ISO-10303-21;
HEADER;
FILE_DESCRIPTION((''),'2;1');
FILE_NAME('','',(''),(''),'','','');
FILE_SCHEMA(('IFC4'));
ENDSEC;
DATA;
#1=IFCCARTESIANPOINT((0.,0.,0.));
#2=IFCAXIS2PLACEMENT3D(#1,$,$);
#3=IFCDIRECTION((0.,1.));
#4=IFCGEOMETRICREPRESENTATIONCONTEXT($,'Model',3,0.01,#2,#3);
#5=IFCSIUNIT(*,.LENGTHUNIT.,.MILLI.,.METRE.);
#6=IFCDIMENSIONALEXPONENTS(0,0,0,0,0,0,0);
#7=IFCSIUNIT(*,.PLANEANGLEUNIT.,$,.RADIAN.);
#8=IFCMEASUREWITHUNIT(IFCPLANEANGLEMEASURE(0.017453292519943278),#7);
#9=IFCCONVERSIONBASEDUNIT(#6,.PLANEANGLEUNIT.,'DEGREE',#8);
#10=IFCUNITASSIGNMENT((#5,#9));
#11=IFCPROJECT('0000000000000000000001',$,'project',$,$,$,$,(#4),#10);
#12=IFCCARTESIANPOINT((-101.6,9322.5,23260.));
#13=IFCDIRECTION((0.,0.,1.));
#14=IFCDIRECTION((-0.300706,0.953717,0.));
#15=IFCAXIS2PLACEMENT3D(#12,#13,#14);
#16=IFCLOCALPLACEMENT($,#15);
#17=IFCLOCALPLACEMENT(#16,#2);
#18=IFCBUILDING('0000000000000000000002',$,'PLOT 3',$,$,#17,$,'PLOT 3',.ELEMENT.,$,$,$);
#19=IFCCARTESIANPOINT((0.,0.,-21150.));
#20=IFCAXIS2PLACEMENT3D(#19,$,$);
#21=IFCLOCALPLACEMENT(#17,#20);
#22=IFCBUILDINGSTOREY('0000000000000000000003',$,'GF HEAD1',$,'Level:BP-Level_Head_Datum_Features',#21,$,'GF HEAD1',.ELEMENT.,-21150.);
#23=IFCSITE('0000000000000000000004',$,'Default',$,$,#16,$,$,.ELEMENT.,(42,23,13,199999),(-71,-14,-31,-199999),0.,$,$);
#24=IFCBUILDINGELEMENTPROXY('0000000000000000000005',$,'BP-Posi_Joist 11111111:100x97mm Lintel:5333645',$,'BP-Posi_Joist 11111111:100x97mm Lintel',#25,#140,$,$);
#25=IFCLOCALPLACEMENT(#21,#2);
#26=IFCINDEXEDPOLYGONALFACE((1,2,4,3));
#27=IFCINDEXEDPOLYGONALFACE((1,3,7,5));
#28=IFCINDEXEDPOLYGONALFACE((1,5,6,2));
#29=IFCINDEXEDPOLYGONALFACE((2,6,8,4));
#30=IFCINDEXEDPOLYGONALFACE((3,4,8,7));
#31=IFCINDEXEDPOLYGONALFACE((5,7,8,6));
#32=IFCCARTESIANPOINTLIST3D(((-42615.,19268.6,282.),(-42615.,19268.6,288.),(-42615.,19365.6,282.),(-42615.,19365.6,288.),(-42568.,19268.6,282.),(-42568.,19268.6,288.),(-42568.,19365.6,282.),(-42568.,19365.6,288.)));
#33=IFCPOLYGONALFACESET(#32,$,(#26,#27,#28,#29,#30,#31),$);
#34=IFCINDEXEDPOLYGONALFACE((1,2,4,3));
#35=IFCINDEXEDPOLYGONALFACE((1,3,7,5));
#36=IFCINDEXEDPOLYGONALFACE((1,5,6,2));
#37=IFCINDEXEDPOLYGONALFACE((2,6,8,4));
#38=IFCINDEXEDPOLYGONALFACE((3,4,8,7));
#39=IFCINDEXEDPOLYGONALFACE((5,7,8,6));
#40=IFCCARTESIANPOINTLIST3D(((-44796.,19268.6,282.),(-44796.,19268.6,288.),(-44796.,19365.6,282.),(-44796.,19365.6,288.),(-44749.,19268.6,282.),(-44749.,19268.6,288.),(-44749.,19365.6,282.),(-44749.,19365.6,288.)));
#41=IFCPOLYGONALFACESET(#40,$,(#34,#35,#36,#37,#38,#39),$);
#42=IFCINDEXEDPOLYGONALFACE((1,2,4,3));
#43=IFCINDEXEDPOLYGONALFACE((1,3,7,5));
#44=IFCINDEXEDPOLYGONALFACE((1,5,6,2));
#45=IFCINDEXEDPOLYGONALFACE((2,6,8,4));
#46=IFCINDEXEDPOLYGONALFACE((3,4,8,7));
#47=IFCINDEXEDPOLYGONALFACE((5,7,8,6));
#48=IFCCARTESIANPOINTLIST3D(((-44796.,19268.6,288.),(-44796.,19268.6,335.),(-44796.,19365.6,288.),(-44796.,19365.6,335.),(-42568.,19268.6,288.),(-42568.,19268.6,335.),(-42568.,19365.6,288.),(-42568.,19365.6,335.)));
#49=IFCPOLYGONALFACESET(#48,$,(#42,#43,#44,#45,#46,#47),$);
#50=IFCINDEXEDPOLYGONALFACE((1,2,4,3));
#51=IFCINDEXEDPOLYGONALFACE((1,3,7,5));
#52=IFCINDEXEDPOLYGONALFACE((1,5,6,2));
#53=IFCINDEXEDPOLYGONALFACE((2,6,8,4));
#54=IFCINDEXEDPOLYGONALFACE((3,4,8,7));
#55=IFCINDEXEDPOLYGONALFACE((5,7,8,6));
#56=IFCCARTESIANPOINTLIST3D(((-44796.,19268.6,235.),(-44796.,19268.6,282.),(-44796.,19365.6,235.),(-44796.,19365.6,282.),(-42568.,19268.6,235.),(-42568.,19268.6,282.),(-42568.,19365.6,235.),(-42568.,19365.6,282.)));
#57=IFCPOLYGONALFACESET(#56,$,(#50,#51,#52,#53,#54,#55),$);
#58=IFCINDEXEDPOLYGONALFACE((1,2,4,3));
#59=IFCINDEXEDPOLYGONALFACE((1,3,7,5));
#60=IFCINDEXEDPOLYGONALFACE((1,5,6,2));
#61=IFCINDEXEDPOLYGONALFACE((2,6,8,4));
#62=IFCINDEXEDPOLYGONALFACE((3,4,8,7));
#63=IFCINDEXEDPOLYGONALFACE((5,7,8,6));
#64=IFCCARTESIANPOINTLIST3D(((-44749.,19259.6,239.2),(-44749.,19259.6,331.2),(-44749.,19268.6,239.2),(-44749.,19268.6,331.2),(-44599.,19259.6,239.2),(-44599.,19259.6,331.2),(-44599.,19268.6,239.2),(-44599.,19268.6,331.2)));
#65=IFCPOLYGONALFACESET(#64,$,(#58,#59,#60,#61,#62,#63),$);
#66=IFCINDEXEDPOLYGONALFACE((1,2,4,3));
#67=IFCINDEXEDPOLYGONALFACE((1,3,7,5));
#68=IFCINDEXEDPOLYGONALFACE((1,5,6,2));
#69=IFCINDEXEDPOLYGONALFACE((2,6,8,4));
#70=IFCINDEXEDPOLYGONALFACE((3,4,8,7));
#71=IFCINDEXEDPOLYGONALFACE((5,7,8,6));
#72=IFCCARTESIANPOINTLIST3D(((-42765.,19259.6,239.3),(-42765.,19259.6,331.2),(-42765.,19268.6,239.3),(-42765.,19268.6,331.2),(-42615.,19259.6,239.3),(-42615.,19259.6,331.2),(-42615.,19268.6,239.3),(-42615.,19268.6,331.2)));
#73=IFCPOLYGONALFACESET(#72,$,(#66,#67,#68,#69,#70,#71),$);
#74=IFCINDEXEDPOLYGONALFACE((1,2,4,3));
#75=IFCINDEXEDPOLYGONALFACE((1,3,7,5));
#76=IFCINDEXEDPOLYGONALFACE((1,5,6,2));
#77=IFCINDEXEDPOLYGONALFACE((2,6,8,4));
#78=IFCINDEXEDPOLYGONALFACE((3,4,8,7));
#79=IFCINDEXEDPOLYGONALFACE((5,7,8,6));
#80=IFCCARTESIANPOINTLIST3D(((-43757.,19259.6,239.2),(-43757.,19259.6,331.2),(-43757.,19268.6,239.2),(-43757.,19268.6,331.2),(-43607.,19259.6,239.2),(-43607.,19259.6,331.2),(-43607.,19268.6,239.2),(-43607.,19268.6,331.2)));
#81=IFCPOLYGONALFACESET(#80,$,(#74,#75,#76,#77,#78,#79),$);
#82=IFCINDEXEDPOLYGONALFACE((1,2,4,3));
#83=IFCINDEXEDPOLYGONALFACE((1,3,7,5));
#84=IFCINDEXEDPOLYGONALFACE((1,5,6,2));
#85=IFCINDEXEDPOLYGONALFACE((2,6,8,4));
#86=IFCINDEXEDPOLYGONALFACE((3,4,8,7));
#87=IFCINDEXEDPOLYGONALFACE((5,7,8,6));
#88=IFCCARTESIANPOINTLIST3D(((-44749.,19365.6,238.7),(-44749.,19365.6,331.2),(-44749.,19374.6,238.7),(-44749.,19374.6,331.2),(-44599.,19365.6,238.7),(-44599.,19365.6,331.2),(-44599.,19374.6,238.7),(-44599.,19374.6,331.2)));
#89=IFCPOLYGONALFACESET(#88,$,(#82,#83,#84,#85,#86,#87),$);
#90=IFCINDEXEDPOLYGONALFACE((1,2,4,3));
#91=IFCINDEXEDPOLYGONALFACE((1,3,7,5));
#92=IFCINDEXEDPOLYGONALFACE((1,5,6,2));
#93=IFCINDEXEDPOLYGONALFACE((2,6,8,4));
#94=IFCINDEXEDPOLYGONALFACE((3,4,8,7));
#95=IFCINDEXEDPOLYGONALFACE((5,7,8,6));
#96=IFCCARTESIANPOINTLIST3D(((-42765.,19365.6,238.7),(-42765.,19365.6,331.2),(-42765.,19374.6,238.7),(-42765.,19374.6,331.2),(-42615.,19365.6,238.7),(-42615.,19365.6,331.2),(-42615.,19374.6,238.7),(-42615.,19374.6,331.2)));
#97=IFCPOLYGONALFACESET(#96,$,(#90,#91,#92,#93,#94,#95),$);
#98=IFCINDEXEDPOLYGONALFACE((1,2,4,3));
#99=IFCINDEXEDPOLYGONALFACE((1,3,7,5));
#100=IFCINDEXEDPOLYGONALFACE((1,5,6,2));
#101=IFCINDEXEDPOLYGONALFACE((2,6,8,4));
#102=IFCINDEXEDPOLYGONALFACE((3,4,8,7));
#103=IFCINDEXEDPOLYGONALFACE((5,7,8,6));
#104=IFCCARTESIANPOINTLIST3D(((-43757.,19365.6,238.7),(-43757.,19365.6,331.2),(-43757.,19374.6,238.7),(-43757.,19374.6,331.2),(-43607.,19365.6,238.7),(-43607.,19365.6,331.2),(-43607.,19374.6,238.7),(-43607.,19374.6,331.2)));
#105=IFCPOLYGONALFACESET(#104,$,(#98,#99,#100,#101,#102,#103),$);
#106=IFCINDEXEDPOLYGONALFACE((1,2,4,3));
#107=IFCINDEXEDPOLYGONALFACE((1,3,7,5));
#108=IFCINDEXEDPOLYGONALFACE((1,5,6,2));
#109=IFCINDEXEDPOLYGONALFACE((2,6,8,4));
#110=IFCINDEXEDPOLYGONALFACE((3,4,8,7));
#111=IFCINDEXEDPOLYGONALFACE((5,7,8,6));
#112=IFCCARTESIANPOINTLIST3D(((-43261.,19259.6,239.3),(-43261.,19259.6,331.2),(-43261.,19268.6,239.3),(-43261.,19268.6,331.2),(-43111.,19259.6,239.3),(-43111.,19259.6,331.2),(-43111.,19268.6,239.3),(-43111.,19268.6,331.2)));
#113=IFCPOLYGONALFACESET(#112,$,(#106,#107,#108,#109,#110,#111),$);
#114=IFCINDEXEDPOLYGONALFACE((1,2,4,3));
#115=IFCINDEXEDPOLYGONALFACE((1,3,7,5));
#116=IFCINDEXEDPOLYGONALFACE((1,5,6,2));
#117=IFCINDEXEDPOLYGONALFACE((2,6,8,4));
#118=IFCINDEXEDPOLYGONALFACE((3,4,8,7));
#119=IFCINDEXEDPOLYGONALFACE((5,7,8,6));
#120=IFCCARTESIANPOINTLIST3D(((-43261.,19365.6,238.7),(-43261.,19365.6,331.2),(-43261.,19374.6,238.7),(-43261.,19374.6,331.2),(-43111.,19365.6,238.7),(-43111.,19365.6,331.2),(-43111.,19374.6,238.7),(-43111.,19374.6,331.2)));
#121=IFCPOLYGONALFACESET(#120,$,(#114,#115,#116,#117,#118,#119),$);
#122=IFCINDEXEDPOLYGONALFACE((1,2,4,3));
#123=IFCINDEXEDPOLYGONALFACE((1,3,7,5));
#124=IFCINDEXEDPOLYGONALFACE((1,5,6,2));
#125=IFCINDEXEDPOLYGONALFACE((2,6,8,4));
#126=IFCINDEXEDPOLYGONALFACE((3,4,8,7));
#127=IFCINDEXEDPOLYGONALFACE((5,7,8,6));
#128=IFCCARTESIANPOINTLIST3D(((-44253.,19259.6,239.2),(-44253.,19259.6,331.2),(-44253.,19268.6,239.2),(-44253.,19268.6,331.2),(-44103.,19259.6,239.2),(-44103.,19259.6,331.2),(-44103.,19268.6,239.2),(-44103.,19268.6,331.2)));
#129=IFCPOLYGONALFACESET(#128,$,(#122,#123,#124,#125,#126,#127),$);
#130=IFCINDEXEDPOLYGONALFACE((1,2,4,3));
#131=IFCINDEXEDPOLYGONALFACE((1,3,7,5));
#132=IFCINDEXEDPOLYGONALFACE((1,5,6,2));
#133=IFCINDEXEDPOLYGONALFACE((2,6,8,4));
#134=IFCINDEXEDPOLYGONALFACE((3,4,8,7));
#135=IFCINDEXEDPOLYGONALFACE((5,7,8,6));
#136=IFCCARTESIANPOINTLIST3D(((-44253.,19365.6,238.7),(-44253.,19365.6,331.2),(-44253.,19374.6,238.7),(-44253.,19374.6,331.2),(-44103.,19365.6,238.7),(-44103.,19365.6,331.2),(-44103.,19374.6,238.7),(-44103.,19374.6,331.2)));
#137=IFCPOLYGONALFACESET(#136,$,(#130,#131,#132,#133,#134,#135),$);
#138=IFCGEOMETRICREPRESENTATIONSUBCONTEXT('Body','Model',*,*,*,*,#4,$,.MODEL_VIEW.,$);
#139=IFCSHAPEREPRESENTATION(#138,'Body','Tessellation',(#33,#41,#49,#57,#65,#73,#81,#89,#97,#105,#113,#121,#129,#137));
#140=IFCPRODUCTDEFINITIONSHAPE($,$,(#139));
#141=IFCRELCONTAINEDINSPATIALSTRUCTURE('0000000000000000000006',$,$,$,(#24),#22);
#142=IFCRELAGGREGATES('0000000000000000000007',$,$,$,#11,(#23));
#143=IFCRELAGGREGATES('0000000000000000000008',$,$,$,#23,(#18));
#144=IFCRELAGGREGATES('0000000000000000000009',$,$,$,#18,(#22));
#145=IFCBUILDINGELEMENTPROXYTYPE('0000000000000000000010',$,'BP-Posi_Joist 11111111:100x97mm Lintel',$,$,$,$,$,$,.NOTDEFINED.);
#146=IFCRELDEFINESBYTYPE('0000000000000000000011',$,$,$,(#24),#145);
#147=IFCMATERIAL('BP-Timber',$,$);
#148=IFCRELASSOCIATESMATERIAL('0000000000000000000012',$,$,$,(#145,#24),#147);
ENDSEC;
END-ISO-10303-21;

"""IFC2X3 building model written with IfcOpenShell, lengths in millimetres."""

from ifc_helpers import new_model, entity, si_unit, converted_unit, direction, frame, frame_2d, origin, origin_2d_with_axis, place, context, subcontext, project, spatial, rectangle, extrude, source, transform, mapped, material, type_object, type_shapes, element, save


model = new_model("IFC2X3")

# Units and contexts
model_context = context("Model", 3, precision=0.01, world=origin(), true_north=direction((0.0, 1.0)))
body_context = subcontext(model_context, "Body", "Model", "MODEL_VIEW")
ifc_project = project(units=[si_unit("LENGTHUNIT", "METRE", prefix="MILLI"), converted_unit("PLANEANGLEUNIT", "DEGREE", entity("IfcPlaneAngleMeasure", 0.017453292519943278), si_unit("PLANEANGLEUNIT", "RADIAN"), dimensions=[0, 0, 0, 0, 0, 0, 0])], contexts=[model_context])

# Site, building, storey
site_placement = place(None, frame((-101.6, 9322.5, 23260.0), z_axis=(0.0, 0.0, 1.0), x_axis=(-0.300706, 0.953717, 0.0)))
site = spatial("IfcSite", under=ifc_project, at=site_placement, Name="Default", CompositionType="ELEMENT", RefLatitude=(42, 23, 13, 199999), RefLongitude=(-71, -14, -31, -199999), RefElevation=0.0)
building_placement = place(site_placement, origin())
building = spatial("IfcBuilding", under=site, at=building_placement, Name="PLOT 3", LongName="PLOT 3", CompositionType="ELEMENT")
storey_placement = place(building_placement, frame((0.0, 0.0, -21150.0)))
storey = spatial("IfcBuildingStorey", under=building, at=storey_placement, Name="GF HEAD1", ObjectType="Level:BP-Level_Head_Datum_Features", LongName="GF HEAD1", CompositionType="ELEMENT", Elevation=-21150.0)

# Shared definitions
ifc_material_1 = material(Name="BP-Timber")

# Building element proxy
building_element_proxy_type_1 = type_object("IfcBuildingElementProxyType", Name="BP-Posi_Joist 11111111:100x97mm Lintel", PredefinedType="NOTDEFINED", material=ifc_material_1)
shared_shape_1 = source(origin(), body_context, "Body", "SweptSolid", [
    extrude(rectangle(XDim=47.0, YDim=97.0, at=origin_2d_with_axis()), frame((320.4, 0.0, -53.0), z_axis=(0.0, 0.0, 1.0), x_axis=(-1.0, 0.0, 0.0)), (0.0, 0.0, 1.0), 6.0),
    extrude(rectangle(XDim=47.0, YDim=97.0, at=frame_2d((0.0, 0.0), x_axis=(1.0, 0.0))), frame((2501.4, 0.0, -53.0), z_axis=(0.0, 0.0, 1.0), x_axis=(-1.0, 0.0, 0.0)), (0.0, 0.0, 1.0), 6.0),
    extrude(rectangle(XDim=97.0, YDim=2228.0, at=frame_2d((0.0, 0.0), x_axis=(1.0, 0.0))), frame((1410.9, 0.0, -47.0), z_axis=(0.0, 0.0, 1.0), x_axis=(0.0, -1.0, 0.0)), (0.0, 0.0, 1.0), 47.0),
    extrude(rectangle(XDim=97.0, YDim=2228.0, at=origin_2d_with_axis()), frame((1410.9, 0.0, -100.0), z_axis=(0.0, 0.0, 1.0), x_axis=(0.0, -1.0, 0.0)), (0.0, 0.0, 1.0), 47.0),
    extrude(rectangle(XDim=9.0, YDim=150.0, at=frame_2d((0.0, 0.0), x_axis=(1.0, 0.0))), frame((2402.9, 53.0, -95.8), z_axis=(0.0, 0.0, 1.0), x_axis=(0.0, -1.0, 0.0)), (0.0, 0.0, 1.0), 92.0),
    extrude(rectangle(XDim=9.0, YDim=150.0, at=frame_2d((0.0, 0.0), x_axis=(1.0, 0.0))), frame((418.9, 53.0, -95.7), z_axis=(0.0, 0.0, 1.0), x_axis=(0.0, 1.0, 0.0)), (0.0, 0.0, 1.0), 92.0),
    extrude(rectangle(XDim=9.0, YDim=150.0, at=frame_2d((0.0, 0.0), x_axis=(1.0, 0.0))), frame((1410.9, 53.0, -95.8), z_axis=(0.0, 0.0, 1.0), x_axis=(0.0, -1.0, 0.0)), (0.0, 0.0, 1.0), 92.0),
    extrude(rectangle(XDim=9.0, YDim=150.0, at=frame_2d((0.0, 0.0), x_axis=(1.0, 0.0))), frame((2402.9, -53.0, -96.3), z_axis=(0.0, 0.0, 1.0), x_axis=(0.0, -1.0, 0.0)), (0.0, 0.0, 1.0), 92.5),
    extrude(rectangle(XDim=9.0, YDim=150.0, at=frame_2d((0.0, 0.0), x_axis=(1.0, 0.0))), frame((418.9, -53.0, -96.3), z_axis=(0.0, 0.0, 1.0), x_axis=(0.0, 1.0, 0.0)), (0.0, 0.0, 1.0), 92.5),
    extrude(rectangle(XDim=9.0, YDim=150.0, at=origin_2d_with_axis()), frame((1410.9, -53.0, -96.3), z_axis=(0.0, 0.0, 1.0), x_axis=(0.0, -1.0, 0.0)), (0.0, 0.0, 1.0), 92.5),
    extrude(rectangle(XDim=9.0, YDim=150.0, at=frame_2d((0.0, 0.0), x_axis=(1.0, 0.0))), frame((914.9, 53.0, -95.7), z_axis=(0.0, 0.0, 1.0), x_axis=(0.0, 1.0, 0.0)), (0.0, 0.0, 1.0), 92.0),
    extrude(rectangle(XDim=9.0, YDim=150.0, at=frame_2d((0.0, 0.0), x_axis=(1.0, 0.0))), frame((914.9, -53.0, -96.3), z_axis=(0.0, 0.0, 1.0), x_axis=(0.0, 1.0, 0.0)), (0.0, 0.0, 1.0), 92.5),
    extrude(rectangle(XDim=9.0, YDim=150.0, at=origin_2d_with_axis()), frame((1906.9, 53.0, -95.8), z_axis=(0.0, 0.0, 1.0), x_axis=(0.0, -1.0, 0.0)), (0.0, 0.0, 1.0), 92.0),
    extrude(rectangle(XDim=9.0, YDim=150.0, at=origin_2d_with_axis()), frame((1906.9, -53.0, -96.3), z_axis=(0.0, 0.0, 1.0), x_axis=(0.0, -1.0, 0.0)), (0.0, 0.0, 1.0), 92.5),
])
type_shapes(building_element_proxy_type_1, [shared_shape_1])
for number, where, z_axis, x_axis, name in (
    (1, (-42271.1, 19317.1, 335.0), (0.0, 0.0, 1.0), (-1.0, 0.0, 0.0), "BP-Posi_Joist 11111111:100x97mm Lintel:5333645"),
):
    element("IfcBuildingElementProxy", number, at=place(storey_placement, frame(where, z_axis=z_axis, x_axis=x_axis)), inside=storey, type_object=building_element_proxy_type_1, material=ifc_material_1, Name=name, ObjectType="BP-Posi_Joist 11111111:100x97mm Lintel", context=body_context, shape_type="MappedRepresentation", body=[
        mapped(shared_shape_1, transform((0.0, 0.0, 0.0), scale=1.0)),
    ])

save(model, "model.ifc")
